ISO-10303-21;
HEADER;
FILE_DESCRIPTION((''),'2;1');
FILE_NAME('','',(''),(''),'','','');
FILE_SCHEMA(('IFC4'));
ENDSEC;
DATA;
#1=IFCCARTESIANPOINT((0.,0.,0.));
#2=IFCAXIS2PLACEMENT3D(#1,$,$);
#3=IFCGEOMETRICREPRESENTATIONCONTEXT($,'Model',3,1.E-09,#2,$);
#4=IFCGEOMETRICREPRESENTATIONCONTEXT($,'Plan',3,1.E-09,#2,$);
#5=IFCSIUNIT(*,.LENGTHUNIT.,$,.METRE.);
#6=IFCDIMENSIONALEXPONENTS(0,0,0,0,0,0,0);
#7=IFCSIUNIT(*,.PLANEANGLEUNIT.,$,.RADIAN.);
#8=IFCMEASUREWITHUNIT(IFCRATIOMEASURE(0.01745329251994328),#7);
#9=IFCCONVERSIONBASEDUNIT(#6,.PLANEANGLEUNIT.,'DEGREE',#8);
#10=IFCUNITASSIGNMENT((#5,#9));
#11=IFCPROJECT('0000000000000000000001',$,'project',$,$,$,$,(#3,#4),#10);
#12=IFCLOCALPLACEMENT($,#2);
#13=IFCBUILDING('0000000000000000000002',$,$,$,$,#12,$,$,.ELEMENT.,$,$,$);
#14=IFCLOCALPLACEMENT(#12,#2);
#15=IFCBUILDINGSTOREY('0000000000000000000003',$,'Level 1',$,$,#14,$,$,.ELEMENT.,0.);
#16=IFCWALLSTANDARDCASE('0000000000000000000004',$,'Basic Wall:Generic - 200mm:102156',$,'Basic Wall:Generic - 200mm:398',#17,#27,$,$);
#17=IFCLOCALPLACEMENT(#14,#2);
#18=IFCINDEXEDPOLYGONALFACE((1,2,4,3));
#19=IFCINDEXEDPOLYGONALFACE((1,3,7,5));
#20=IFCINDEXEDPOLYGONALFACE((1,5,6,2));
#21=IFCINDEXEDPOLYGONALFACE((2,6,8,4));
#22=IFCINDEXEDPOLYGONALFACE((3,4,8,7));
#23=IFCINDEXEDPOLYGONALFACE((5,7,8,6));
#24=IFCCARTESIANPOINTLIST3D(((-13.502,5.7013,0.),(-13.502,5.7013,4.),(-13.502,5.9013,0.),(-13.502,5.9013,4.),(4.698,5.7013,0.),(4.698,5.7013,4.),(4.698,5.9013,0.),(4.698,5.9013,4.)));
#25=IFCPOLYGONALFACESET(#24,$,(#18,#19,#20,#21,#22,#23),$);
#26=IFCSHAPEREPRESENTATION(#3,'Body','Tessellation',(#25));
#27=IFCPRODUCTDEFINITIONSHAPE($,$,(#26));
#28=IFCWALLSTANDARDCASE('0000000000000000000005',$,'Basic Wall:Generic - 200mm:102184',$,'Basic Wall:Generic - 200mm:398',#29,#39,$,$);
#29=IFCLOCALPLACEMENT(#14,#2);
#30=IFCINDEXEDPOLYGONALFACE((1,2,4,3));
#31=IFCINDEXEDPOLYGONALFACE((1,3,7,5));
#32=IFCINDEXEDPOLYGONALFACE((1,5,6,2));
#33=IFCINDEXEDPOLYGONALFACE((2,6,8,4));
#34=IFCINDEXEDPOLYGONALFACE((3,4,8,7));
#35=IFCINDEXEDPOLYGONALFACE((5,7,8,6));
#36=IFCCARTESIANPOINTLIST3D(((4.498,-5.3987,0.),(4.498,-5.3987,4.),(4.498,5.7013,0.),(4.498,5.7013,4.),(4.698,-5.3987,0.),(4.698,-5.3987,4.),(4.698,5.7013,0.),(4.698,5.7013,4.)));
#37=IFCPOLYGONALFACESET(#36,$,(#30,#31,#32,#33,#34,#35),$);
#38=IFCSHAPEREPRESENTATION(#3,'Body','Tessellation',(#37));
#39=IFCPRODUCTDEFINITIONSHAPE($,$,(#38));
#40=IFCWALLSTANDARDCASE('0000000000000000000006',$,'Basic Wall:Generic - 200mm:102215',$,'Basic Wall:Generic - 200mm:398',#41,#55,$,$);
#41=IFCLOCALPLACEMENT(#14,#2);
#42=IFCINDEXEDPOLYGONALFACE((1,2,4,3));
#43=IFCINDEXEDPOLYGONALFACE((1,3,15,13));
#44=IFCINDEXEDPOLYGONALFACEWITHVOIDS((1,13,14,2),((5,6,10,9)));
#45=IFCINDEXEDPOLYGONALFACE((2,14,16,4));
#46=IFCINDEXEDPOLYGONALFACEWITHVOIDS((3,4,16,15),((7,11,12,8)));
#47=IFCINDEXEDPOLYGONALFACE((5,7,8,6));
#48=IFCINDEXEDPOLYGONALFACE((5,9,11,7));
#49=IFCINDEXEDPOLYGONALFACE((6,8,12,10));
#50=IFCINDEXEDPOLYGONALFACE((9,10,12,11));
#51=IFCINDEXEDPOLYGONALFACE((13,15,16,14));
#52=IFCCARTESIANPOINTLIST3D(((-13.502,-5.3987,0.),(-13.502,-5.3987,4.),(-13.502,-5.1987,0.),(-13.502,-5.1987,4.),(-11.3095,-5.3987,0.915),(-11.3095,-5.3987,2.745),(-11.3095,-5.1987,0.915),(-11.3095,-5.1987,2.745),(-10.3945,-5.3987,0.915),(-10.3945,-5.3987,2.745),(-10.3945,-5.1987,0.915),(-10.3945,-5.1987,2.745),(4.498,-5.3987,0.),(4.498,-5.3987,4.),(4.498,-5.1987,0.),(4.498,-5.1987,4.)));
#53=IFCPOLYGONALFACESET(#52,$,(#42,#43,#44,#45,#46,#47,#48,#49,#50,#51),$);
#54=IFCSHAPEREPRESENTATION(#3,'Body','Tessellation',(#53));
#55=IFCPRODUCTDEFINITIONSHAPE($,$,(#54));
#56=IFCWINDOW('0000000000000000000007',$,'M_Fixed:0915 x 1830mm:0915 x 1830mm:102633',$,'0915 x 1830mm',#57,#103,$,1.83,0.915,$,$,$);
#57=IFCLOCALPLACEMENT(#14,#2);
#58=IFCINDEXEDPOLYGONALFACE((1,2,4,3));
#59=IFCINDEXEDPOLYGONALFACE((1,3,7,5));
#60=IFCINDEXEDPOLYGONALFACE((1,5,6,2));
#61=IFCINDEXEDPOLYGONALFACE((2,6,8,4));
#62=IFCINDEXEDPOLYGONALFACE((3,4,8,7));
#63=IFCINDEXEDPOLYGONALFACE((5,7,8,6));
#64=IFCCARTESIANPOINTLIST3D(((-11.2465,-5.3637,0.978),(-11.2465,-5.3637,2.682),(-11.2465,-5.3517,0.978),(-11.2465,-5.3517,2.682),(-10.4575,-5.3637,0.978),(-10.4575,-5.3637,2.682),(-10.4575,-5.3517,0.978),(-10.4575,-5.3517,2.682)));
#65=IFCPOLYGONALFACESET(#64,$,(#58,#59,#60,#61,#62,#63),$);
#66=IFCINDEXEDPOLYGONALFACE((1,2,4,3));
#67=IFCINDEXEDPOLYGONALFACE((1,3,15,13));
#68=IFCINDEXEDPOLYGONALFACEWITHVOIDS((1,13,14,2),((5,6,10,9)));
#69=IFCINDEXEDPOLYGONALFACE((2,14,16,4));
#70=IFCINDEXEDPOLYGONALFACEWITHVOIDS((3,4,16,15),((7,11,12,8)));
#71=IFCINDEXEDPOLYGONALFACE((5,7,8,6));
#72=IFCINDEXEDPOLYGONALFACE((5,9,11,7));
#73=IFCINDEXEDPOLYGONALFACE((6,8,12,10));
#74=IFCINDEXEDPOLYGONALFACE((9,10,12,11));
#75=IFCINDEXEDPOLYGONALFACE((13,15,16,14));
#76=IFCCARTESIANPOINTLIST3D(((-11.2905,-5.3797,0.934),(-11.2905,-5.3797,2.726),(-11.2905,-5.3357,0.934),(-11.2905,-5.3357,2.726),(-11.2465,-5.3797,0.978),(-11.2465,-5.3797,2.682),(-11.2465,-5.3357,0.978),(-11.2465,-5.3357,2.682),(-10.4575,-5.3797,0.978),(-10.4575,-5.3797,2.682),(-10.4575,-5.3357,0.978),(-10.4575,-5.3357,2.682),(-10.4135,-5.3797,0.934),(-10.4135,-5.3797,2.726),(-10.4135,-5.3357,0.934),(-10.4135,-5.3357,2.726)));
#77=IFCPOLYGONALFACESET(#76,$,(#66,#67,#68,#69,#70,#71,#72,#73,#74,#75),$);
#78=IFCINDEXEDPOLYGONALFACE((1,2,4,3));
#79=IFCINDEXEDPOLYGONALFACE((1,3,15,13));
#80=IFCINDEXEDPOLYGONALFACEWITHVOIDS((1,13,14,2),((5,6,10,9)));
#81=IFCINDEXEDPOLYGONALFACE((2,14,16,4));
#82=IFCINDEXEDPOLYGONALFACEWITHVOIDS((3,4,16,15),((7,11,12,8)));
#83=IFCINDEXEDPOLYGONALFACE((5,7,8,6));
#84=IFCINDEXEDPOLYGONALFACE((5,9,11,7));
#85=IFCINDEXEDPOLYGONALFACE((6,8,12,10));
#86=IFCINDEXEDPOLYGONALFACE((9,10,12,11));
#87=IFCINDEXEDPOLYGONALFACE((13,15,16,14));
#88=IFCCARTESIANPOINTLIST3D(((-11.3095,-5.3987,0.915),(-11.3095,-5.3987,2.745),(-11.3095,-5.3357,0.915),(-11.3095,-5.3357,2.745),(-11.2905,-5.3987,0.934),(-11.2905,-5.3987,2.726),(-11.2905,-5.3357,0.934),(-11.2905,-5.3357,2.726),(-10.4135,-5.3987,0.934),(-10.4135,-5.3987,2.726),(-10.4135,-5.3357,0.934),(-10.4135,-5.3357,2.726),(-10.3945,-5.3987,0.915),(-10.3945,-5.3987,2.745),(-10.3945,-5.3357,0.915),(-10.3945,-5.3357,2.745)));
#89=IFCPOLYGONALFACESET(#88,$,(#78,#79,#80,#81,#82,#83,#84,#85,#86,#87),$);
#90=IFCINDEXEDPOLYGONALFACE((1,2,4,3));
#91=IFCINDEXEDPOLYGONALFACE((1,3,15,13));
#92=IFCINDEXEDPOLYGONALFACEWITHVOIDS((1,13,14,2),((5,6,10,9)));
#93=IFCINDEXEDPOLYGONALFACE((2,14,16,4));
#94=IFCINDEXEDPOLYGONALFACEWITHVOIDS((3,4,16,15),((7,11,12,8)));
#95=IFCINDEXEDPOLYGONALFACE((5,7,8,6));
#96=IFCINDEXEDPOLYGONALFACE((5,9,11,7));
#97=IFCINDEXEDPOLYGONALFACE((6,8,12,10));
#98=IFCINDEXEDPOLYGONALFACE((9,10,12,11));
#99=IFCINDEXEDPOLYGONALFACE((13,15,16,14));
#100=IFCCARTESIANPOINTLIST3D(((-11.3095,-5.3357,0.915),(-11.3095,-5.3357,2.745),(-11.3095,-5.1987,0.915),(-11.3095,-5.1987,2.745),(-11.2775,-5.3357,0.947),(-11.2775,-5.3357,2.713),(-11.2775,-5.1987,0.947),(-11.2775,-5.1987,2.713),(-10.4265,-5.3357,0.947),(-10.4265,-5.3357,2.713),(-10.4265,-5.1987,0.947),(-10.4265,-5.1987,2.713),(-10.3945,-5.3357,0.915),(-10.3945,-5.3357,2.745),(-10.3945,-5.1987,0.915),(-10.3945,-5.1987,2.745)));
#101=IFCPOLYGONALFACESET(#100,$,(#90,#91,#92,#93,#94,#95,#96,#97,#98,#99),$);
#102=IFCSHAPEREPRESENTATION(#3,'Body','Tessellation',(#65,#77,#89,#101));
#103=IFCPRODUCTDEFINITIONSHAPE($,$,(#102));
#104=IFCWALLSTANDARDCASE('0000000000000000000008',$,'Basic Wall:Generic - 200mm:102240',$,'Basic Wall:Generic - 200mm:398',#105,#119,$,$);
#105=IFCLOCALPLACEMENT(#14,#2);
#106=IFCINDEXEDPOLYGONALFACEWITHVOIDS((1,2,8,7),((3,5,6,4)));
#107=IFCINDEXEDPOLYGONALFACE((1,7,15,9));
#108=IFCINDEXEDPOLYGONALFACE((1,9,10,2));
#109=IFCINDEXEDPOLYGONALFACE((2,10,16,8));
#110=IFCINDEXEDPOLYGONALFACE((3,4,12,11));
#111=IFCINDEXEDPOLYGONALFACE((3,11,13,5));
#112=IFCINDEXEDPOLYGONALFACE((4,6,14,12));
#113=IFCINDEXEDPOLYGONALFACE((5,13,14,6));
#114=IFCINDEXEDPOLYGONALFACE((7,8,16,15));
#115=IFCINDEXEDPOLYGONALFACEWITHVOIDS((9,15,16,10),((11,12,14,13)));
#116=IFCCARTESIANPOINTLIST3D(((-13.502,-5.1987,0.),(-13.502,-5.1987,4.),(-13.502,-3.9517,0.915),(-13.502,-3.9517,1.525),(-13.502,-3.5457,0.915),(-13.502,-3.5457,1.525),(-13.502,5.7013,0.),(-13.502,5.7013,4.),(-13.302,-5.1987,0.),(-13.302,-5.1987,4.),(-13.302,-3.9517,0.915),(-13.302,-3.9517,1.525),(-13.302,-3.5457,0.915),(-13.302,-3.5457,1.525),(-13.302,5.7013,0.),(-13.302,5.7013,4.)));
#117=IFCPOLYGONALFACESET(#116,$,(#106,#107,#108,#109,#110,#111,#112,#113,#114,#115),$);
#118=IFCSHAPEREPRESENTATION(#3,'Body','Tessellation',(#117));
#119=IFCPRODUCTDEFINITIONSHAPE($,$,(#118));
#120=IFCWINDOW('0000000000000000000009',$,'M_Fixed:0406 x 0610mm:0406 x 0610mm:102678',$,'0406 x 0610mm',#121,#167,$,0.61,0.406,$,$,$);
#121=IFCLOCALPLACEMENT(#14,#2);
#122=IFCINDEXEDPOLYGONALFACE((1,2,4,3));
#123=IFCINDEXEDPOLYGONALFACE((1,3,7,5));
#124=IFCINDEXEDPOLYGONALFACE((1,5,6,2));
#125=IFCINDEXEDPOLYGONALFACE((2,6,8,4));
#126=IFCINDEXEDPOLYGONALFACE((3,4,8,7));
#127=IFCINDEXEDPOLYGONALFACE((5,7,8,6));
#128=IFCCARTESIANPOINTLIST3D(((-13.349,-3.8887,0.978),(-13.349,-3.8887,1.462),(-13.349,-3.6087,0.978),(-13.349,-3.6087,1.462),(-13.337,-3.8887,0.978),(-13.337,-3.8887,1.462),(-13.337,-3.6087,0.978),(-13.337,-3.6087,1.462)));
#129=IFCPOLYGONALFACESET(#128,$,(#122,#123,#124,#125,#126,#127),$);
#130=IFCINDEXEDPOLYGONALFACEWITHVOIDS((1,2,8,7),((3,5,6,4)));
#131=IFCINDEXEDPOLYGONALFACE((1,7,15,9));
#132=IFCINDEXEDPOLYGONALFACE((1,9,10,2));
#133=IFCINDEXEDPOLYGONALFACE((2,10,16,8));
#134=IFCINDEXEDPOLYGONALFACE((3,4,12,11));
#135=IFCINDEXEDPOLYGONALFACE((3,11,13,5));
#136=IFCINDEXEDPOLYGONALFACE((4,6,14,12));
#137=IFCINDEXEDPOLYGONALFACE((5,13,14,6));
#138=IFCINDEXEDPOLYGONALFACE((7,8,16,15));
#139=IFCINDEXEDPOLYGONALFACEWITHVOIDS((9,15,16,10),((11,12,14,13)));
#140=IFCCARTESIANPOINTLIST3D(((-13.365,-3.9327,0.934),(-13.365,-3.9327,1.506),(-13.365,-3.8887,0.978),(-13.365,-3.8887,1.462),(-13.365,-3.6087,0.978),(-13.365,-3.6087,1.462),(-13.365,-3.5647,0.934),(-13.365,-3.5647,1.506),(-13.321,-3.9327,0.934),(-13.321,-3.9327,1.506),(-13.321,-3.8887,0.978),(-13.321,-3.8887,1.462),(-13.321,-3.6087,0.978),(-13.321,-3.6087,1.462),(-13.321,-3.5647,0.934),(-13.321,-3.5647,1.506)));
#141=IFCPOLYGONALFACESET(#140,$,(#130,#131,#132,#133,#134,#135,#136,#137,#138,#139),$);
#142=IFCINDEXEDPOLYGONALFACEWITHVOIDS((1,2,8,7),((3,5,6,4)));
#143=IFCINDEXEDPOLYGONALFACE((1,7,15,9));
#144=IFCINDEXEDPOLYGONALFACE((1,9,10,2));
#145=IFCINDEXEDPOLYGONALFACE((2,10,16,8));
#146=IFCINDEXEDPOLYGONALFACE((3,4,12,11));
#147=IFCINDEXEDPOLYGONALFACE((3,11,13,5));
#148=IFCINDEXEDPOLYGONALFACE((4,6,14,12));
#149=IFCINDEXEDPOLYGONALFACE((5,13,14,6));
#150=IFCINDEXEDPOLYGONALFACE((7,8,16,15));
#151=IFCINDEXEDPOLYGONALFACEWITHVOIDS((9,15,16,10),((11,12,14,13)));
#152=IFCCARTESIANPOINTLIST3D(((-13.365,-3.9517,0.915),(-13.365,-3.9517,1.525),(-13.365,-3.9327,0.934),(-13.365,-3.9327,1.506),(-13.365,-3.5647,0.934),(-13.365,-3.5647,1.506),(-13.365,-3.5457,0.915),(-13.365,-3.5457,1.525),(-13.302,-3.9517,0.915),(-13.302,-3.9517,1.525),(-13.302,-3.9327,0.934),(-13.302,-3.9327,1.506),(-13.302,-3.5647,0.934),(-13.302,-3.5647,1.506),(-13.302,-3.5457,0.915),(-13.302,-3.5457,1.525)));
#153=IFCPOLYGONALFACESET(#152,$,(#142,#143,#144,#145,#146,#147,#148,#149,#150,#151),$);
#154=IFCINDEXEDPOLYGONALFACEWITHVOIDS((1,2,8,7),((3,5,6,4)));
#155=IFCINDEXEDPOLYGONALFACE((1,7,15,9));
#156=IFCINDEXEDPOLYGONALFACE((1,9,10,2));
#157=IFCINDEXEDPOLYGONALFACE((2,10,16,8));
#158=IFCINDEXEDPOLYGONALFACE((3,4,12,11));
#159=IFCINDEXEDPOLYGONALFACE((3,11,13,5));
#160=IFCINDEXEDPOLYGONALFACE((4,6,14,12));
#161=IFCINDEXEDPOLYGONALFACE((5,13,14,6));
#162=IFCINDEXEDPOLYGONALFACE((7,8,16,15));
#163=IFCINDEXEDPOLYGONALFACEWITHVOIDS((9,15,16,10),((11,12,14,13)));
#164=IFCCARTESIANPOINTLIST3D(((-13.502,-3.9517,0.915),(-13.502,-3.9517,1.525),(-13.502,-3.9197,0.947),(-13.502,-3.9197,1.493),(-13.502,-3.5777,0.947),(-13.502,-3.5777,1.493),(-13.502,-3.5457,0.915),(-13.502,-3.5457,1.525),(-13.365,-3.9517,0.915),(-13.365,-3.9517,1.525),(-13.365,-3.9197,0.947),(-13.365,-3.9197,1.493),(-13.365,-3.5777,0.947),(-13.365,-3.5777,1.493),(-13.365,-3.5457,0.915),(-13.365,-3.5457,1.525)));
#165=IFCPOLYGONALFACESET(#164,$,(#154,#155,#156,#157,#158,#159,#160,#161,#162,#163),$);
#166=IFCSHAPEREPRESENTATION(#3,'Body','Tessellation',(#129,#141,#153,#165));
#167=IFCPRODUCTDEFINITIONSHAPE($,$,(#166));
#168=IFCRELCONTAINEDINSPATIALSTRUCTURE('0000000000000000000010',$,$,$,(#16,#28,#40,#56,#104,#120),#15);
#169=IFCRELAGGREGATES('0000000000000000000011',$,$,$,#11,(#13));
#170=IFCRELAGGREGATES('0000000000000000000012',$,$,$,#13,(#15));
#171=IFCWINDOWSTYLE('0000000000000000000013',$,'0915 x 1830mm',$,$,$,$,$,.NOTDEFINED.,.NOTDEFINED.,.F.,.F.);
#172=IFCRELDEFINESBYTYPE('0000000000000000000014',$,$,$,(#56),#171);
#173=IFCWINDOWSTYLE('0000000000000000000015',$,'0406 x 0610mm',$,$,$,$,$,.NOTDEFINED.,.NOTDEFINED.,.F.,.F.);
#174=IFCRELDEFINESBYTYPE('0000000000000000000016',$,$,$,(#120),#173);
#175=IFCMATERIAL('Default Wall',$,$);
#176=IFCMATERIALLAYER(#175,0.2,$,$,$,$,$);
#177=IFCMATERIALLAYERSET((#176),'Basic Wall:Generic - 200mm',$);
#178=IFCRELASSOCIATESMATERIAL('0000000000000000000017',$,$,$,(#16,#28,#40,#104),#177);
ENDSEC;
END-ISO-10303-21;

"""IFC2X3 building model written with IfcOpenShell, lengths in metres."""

from ifc_helpers import new_model, entity, si_unit, converted_unit, frame, frame_2d, origin, origin_2d_with_axis, place, context, project, spatial, polyline, rectangle, outline, extrude, source, transform, mapped, material, layer, layer_set, layer_usage, type_object, type_shapes, element, fill, save


model = new_model("IFC2X3")

# Units and contexts
model_context = context("Model", 3, precision=1e-09, world=origin())
plan_context = context("Plan", 3, precision=1e-09, world=origin())
ifc_project = project(units=[si_unit("LENGTHUNIT", "METRE"), converted_unit("PLANEANGLEUNIT", "DEGREE", entity("IfcRatioMeasure", 0.01745329251994328), si_unit("PLANEANGLEUNIT", "RADIAN"), dimensions=[0, 0, 0, 0, 0, 0, 0])], contexts=[model_context, plan_context])

# Building, storey
building_placement = place(None, origin())
building = spatial("IfcBuilding", under=ifc_project, at=building_placement, CompositionType="ELEMENT")
storey_placement = place(building_placement, origin())
storey = spatial("IfcBuildingStorey", under=building, at=storey_placement, Name="Level 1", CompositionType="ELEMENT", Elevation=0.0)

# Walls
ifc_material = material(Name="Default Wall")
ifc_layer = layer(ifc_material, 0.2)
ifc_layer_set = layer_set([ifc_layer], Name="Basic Wall:Generic - 200mm")
ifc_layer_usage_1 = layer_usage(ifc_layer_set, "AXIS2", "NEGATIVE", 0.1)
wall_1_placement = place(storey_placement, frame((-13.502, 5.8013, 0.0)))
element("IfcWallStandardCase", 1, at=wall_1_placement, inside=storey, material=ifc_layer_usage_1, Name="Basic Wall:Generic - 200mm:102156", ObjectType="Basic Wall:Generic - 200mm:398", context=model_context, shape_type="SweptSolid", body=[
    extrude(rectangle(XDim=18.2, YDim=0.2, at=frame_2d((9.1, 0.0), x_axis=(-1.0, 0.0))), origin(), (0.0, 0.0, 1.0), 4.0),
])
ifc_layer_usage_2 = layer_usage(ifc_layer_set, "AXIS2", "NEGATIVE", 0.1)
wall_2_placement = place(storey_placement, frame((4.598, 5.7013, 0.0), z_axis=(0.0, 0.0, 1.0), x_axis=(0.0, -1.0, 0.0)))
element("IfcWallStandardCase", 2, at=wall_2_placement, inside=storey, material=ifc_layer_usage_2, Name="Basic Wall:Generic - 200mm:102184", ObjectType="Basic Wall:Generic - 200mm:398", context=model_context, shape_type="SweptSolid", body=[
    extrude(rectangle(XDim=11.1, YDim=0.2, at=frame_2d((5.55, 0.0), x_axis=(-1.0, 0.0))), origin(), (0.0, 0.0, 1.0), 4.0),
])

# Walls, openings, windows
ifc_layer_usage_3 = layer_usage(ifc_layer_set, "AXIS2", "NEGATIVE", 0.1)
wall_3_placement = place(storey_placement, frame((4.498, -5.2987, 0.0), z_axis=(0.0, 0.0, 1.0), x_axis=(-1.0, 0.0, 0.0)))
wall_3 = element("IfcWallStandardCase", 3, at=wall_3_placement, inside=storey, material=ifc_layer_usage_3, Name="Basic Wall:Generic - 200mm:102215", ObjectType="Basic Wall:Generic - 200mm:398", context=model_context, shape_type="SweptSolid", body=[
    extrude(rectangle(XDim=18.0, YDim=0.2, at=frame_2d((9.0, 0.0), x_axis=(-1.0, 0.0))), origin(), (0.0, 0.0, 1.0), 4.0),
])
opening_1_placement = place(wall_3_placement, frame((14.8925, -0.1, 0.915)))
opening_1 = element("IfcOpeningElement", 4, at=opening_1_placement, cuts=wall_3, ObjectType="Opening", context=model_context, shape_type="SweptSolid", body=[
    extrude(rectangle(XDim=1.83, YDim=0.915, at=frame_2d((0.915, 0.4575), x_axis=(1.0, 0.0))), frame((0.0, 0.0, 0.0), z_axis=(0.0, 1.0, 0.0), x_axis=(0.0, 0.0, 1.0)), (0.0, 0.0, 1.0), 0.2),
])
window_style_1 = type_object("IfcWindowStyle", Name="0915 x 1830mm", ConstructionType="NOTDEFINED", OperationType="NOTDEFINED", ParameterTakesPrecedence=False, Sizeable=False)
shared_shape_1 = source(origin(), model_context, "Body", "SweptSolid", [
    extrude(rectangle(XDim=0.012, YDim=0.789, at=origin_2d_with_axis()), frame((0.4575, 0.159, 0.063), z_axis=(0.0, 0.0, 1.0), x_axis=(0.0, -1.0, 0.0)), (0.0, 0.0, 1.0), 1.704),
    extrude(outline(polyline([(-0.4385, -0.896), (0.4385, -0.896), (0.4385, 0.896), (-0.4385, 0.896), (-0.4385, -0.896)]), holes=[polyline([(-0.3945, -0.852), (-0.3945, 0.852), (0.3945, 0.852), (0.3945, -0.852), (-0.3945, -0.852)])]), frame((0.4575, 0.137, 0.915), z_axis=(0.0, 1.0, 0.0), x_axis=(1.0, 0.0, 0.0)), (0.0, 0.0, 1.0), 0.044),
    extrude(outline(polyline([(-0.4575, -0.915), (0.4575, -0.915), (0.4575, 0.915), (-0.4575, 0.915), (-0.4575, -0.915)]), holes=[polyline([(-0.4385, -0.896), (-0.4385, 0.896), (0.4385, 0.896), (0.4385, -0.896), (-0.4385, -0.896)])]), frame((0.4575, 0.137, 0.915), z_axis=(0.0, 1.0, 0.0), x_axis=(1.0, 0.0, 0.0)), (0.0, 0.0, 1.0), 0.063),
    extrude(outline(polyline([(-0.4575, -0.915), (0.4575, -0.915), (0.4575, 0.915), (-0.4575, 0.915), (-0.4575, -0.915)]), holes=[polyline([(-0.4255, -0.883), (-0.4255, 0.883), (0.4255, 0.883), (0.4255, -0.883), (-0.4255, -0.883)])]), frame((0.4575, 0.0, 0.915), z_axis=(0.0, 1.0, 0.0), x_axis=(1.0, 0.0, 0.0)), (0.0, 0.0, 1.0), 0.137),
])
type_shapes(window_style_1, [shared_shape_1])
window_1_placement = place(opening_1_placement, origin())
window_1 = element("IfcWindow", 5, at=window_1_placement, inside=storey, type_object=window_style_1, Name="M_Fixed:0915 x 1830mm:0915 x 1830mm:102633", ObjectType="0915 x 1830mm", OverallHeight=1.83, OverallWidth=0.915, context=model_context, shape_type="MappedRepresentation", body=[
    mapped(shared_shape_1, transform((0.0, 0.0, 0.0), scale=1.0)),
])
fill(opening_1, window_1)
ifc_layer_usage_4 = layer_usage(ifc_layer_set, "AXIS2", "NEGATIVE", 0.1)
wall_4_placement = place(storey_placement, frame((-13.402, -5.1987, 0.0), z_axis=(0.0, 0.0, 1.0), x_axis=(0.0, 1.0, 0.0)))
wall_4 = element("IfcWallStandardCase", 6, at=wall_4_placement, inside=storey, material=ifc_layer_usage_4, Name="Basic Wall:Generic - 200mm:102240", ObjectType="Basic Wall:Generic - 200mm:398", context=model_context, shape_type="SweptSolid", body=[
    extrude(rectangle(XDim=10.9, YDim=0.2, at=frame_2d((5.45, 0.0), x_axis=(-1.0, 0.0))), origin(), (0.0, 0.0, 1.0), 4.0),
])
opening_2_placement = place(wall_4_placement, frame((1.247, -0.1, 0.915)))
opening_2 = element("IfcOpeningElement", 7, at=opening_2_placement, cuts=wall_4, ObjectType="Opening", context=model_context, shape_type="SweptSolid", body=[
    extrude(rectangle(XDim=0.61, YDim=0.406, at=frame_2d((0.305, 0.203), x_axis=(1.0, 0.0))), frame((0.0, 0.0, 0.0), z_axis=(0.0, 1.0, 0.0), x_axis=(0.0, 0.0, 1.0)), (0.0, 0.0, 1.0), 0.2),
])
window_style_2 = type_object("IfcWindowStyle", Name="0406 x 0610mm", ConstructionType="NOTDEFINED", OperationType="NOTDEFINED", ParameterTakesPrecedence=False, Sizeable=False)
shared_shape_2 = source(origin(), model_context, "Body", "SweptSolid", [
    extrude(rectangle(XDim=0.012, YDim=0.28, at=origin_2d_with_axis()), frame((0.203, 0.159, 0.063), z_axis=(0.0, 0.0, 1.0), x_axis=(0.0, -1.0, 0.0)), (0.0, 0.0, 1.0), 0.484),
    extrude(outline(polyline([(-0.184, -0.286), (0.184, -0.286), (0.184, 0.286), (-0.184, 0.286), (-0.184, -0.286)]), holes=[polyline([(-0.14, -0.242), (-0.14, 0.242), (0.14, 0.242), (0.14, -0.242), (-0.14, -0.242)])]), frame((0.203, 0.137, 0.305), z_axis=(0.0, 1.0, 0.0), x_axis=(1.0, 0.0, 0.0)), (0.0, 0.0, 1.0), 0.044),
    extrude(outline(polyline([(-0.203, -0.305), (0.203, -0.305), (0.203, 0.305), (-0.203, 0.305), (-0.203, -0.305)]), holes=[polyline([(-0.184, -0.286), (-0.184, 0.286), (0.184, 0.286), (0.184, -0.286), (-0.184, -0.286)])]), frame((0.203, 0.137, 0.305), z_axis=(0.0, 1.0, 0.0), x_axis=(1.0, 0.0, 0.0)), (0.0, 0.0, 1.0), 0.063),
    extrude(outline(polyline([(-0.203, -0.305), (0.203, -0.305), (0.203, 0.305), (-0.203, 0.305), (-0.203, -0.305)]), holes=[polyline([(-0.171, -0.273), (-0.171, 0.273), (0.171, 0.273), (0.171, -0.273), (-0.171, -0.273)])]), frame((0.203, 0.0, 0.305), z_axis=(0.0, 1.0, 0.0), x_axis=(1.0, 0.0, 0.0)), (0.0, 0.0, 1.0), 0.137),
])
type_shapes(window_style_2, [shared_shape_2])
window_2_placement = place(opening_2_placement, frame((0.406, 0.2, 0.0), z_axis=(0.0, 0.0, 1.0), x_axis=(-1.0, 0.0, 0.0)))
window_2 = element("IfcWindow", 8, at=window_2_placement, inside=storey, type_object=window_style_2, Name="M_Fixed:0406 x 0610mm:0406 x 0610mm:102678", ObjectType="0406 x 0610mm", OverallHeight=0.61, OverallWidth=0.406, context=model_context, shape_type="MappedRepresentation", body=[
    mapped(shared_shape_2, transform((0.0, 0.0, 0.0), scale=1.0)),
])
fill(opening_2, window_2)

save(model, "model.ifc")
